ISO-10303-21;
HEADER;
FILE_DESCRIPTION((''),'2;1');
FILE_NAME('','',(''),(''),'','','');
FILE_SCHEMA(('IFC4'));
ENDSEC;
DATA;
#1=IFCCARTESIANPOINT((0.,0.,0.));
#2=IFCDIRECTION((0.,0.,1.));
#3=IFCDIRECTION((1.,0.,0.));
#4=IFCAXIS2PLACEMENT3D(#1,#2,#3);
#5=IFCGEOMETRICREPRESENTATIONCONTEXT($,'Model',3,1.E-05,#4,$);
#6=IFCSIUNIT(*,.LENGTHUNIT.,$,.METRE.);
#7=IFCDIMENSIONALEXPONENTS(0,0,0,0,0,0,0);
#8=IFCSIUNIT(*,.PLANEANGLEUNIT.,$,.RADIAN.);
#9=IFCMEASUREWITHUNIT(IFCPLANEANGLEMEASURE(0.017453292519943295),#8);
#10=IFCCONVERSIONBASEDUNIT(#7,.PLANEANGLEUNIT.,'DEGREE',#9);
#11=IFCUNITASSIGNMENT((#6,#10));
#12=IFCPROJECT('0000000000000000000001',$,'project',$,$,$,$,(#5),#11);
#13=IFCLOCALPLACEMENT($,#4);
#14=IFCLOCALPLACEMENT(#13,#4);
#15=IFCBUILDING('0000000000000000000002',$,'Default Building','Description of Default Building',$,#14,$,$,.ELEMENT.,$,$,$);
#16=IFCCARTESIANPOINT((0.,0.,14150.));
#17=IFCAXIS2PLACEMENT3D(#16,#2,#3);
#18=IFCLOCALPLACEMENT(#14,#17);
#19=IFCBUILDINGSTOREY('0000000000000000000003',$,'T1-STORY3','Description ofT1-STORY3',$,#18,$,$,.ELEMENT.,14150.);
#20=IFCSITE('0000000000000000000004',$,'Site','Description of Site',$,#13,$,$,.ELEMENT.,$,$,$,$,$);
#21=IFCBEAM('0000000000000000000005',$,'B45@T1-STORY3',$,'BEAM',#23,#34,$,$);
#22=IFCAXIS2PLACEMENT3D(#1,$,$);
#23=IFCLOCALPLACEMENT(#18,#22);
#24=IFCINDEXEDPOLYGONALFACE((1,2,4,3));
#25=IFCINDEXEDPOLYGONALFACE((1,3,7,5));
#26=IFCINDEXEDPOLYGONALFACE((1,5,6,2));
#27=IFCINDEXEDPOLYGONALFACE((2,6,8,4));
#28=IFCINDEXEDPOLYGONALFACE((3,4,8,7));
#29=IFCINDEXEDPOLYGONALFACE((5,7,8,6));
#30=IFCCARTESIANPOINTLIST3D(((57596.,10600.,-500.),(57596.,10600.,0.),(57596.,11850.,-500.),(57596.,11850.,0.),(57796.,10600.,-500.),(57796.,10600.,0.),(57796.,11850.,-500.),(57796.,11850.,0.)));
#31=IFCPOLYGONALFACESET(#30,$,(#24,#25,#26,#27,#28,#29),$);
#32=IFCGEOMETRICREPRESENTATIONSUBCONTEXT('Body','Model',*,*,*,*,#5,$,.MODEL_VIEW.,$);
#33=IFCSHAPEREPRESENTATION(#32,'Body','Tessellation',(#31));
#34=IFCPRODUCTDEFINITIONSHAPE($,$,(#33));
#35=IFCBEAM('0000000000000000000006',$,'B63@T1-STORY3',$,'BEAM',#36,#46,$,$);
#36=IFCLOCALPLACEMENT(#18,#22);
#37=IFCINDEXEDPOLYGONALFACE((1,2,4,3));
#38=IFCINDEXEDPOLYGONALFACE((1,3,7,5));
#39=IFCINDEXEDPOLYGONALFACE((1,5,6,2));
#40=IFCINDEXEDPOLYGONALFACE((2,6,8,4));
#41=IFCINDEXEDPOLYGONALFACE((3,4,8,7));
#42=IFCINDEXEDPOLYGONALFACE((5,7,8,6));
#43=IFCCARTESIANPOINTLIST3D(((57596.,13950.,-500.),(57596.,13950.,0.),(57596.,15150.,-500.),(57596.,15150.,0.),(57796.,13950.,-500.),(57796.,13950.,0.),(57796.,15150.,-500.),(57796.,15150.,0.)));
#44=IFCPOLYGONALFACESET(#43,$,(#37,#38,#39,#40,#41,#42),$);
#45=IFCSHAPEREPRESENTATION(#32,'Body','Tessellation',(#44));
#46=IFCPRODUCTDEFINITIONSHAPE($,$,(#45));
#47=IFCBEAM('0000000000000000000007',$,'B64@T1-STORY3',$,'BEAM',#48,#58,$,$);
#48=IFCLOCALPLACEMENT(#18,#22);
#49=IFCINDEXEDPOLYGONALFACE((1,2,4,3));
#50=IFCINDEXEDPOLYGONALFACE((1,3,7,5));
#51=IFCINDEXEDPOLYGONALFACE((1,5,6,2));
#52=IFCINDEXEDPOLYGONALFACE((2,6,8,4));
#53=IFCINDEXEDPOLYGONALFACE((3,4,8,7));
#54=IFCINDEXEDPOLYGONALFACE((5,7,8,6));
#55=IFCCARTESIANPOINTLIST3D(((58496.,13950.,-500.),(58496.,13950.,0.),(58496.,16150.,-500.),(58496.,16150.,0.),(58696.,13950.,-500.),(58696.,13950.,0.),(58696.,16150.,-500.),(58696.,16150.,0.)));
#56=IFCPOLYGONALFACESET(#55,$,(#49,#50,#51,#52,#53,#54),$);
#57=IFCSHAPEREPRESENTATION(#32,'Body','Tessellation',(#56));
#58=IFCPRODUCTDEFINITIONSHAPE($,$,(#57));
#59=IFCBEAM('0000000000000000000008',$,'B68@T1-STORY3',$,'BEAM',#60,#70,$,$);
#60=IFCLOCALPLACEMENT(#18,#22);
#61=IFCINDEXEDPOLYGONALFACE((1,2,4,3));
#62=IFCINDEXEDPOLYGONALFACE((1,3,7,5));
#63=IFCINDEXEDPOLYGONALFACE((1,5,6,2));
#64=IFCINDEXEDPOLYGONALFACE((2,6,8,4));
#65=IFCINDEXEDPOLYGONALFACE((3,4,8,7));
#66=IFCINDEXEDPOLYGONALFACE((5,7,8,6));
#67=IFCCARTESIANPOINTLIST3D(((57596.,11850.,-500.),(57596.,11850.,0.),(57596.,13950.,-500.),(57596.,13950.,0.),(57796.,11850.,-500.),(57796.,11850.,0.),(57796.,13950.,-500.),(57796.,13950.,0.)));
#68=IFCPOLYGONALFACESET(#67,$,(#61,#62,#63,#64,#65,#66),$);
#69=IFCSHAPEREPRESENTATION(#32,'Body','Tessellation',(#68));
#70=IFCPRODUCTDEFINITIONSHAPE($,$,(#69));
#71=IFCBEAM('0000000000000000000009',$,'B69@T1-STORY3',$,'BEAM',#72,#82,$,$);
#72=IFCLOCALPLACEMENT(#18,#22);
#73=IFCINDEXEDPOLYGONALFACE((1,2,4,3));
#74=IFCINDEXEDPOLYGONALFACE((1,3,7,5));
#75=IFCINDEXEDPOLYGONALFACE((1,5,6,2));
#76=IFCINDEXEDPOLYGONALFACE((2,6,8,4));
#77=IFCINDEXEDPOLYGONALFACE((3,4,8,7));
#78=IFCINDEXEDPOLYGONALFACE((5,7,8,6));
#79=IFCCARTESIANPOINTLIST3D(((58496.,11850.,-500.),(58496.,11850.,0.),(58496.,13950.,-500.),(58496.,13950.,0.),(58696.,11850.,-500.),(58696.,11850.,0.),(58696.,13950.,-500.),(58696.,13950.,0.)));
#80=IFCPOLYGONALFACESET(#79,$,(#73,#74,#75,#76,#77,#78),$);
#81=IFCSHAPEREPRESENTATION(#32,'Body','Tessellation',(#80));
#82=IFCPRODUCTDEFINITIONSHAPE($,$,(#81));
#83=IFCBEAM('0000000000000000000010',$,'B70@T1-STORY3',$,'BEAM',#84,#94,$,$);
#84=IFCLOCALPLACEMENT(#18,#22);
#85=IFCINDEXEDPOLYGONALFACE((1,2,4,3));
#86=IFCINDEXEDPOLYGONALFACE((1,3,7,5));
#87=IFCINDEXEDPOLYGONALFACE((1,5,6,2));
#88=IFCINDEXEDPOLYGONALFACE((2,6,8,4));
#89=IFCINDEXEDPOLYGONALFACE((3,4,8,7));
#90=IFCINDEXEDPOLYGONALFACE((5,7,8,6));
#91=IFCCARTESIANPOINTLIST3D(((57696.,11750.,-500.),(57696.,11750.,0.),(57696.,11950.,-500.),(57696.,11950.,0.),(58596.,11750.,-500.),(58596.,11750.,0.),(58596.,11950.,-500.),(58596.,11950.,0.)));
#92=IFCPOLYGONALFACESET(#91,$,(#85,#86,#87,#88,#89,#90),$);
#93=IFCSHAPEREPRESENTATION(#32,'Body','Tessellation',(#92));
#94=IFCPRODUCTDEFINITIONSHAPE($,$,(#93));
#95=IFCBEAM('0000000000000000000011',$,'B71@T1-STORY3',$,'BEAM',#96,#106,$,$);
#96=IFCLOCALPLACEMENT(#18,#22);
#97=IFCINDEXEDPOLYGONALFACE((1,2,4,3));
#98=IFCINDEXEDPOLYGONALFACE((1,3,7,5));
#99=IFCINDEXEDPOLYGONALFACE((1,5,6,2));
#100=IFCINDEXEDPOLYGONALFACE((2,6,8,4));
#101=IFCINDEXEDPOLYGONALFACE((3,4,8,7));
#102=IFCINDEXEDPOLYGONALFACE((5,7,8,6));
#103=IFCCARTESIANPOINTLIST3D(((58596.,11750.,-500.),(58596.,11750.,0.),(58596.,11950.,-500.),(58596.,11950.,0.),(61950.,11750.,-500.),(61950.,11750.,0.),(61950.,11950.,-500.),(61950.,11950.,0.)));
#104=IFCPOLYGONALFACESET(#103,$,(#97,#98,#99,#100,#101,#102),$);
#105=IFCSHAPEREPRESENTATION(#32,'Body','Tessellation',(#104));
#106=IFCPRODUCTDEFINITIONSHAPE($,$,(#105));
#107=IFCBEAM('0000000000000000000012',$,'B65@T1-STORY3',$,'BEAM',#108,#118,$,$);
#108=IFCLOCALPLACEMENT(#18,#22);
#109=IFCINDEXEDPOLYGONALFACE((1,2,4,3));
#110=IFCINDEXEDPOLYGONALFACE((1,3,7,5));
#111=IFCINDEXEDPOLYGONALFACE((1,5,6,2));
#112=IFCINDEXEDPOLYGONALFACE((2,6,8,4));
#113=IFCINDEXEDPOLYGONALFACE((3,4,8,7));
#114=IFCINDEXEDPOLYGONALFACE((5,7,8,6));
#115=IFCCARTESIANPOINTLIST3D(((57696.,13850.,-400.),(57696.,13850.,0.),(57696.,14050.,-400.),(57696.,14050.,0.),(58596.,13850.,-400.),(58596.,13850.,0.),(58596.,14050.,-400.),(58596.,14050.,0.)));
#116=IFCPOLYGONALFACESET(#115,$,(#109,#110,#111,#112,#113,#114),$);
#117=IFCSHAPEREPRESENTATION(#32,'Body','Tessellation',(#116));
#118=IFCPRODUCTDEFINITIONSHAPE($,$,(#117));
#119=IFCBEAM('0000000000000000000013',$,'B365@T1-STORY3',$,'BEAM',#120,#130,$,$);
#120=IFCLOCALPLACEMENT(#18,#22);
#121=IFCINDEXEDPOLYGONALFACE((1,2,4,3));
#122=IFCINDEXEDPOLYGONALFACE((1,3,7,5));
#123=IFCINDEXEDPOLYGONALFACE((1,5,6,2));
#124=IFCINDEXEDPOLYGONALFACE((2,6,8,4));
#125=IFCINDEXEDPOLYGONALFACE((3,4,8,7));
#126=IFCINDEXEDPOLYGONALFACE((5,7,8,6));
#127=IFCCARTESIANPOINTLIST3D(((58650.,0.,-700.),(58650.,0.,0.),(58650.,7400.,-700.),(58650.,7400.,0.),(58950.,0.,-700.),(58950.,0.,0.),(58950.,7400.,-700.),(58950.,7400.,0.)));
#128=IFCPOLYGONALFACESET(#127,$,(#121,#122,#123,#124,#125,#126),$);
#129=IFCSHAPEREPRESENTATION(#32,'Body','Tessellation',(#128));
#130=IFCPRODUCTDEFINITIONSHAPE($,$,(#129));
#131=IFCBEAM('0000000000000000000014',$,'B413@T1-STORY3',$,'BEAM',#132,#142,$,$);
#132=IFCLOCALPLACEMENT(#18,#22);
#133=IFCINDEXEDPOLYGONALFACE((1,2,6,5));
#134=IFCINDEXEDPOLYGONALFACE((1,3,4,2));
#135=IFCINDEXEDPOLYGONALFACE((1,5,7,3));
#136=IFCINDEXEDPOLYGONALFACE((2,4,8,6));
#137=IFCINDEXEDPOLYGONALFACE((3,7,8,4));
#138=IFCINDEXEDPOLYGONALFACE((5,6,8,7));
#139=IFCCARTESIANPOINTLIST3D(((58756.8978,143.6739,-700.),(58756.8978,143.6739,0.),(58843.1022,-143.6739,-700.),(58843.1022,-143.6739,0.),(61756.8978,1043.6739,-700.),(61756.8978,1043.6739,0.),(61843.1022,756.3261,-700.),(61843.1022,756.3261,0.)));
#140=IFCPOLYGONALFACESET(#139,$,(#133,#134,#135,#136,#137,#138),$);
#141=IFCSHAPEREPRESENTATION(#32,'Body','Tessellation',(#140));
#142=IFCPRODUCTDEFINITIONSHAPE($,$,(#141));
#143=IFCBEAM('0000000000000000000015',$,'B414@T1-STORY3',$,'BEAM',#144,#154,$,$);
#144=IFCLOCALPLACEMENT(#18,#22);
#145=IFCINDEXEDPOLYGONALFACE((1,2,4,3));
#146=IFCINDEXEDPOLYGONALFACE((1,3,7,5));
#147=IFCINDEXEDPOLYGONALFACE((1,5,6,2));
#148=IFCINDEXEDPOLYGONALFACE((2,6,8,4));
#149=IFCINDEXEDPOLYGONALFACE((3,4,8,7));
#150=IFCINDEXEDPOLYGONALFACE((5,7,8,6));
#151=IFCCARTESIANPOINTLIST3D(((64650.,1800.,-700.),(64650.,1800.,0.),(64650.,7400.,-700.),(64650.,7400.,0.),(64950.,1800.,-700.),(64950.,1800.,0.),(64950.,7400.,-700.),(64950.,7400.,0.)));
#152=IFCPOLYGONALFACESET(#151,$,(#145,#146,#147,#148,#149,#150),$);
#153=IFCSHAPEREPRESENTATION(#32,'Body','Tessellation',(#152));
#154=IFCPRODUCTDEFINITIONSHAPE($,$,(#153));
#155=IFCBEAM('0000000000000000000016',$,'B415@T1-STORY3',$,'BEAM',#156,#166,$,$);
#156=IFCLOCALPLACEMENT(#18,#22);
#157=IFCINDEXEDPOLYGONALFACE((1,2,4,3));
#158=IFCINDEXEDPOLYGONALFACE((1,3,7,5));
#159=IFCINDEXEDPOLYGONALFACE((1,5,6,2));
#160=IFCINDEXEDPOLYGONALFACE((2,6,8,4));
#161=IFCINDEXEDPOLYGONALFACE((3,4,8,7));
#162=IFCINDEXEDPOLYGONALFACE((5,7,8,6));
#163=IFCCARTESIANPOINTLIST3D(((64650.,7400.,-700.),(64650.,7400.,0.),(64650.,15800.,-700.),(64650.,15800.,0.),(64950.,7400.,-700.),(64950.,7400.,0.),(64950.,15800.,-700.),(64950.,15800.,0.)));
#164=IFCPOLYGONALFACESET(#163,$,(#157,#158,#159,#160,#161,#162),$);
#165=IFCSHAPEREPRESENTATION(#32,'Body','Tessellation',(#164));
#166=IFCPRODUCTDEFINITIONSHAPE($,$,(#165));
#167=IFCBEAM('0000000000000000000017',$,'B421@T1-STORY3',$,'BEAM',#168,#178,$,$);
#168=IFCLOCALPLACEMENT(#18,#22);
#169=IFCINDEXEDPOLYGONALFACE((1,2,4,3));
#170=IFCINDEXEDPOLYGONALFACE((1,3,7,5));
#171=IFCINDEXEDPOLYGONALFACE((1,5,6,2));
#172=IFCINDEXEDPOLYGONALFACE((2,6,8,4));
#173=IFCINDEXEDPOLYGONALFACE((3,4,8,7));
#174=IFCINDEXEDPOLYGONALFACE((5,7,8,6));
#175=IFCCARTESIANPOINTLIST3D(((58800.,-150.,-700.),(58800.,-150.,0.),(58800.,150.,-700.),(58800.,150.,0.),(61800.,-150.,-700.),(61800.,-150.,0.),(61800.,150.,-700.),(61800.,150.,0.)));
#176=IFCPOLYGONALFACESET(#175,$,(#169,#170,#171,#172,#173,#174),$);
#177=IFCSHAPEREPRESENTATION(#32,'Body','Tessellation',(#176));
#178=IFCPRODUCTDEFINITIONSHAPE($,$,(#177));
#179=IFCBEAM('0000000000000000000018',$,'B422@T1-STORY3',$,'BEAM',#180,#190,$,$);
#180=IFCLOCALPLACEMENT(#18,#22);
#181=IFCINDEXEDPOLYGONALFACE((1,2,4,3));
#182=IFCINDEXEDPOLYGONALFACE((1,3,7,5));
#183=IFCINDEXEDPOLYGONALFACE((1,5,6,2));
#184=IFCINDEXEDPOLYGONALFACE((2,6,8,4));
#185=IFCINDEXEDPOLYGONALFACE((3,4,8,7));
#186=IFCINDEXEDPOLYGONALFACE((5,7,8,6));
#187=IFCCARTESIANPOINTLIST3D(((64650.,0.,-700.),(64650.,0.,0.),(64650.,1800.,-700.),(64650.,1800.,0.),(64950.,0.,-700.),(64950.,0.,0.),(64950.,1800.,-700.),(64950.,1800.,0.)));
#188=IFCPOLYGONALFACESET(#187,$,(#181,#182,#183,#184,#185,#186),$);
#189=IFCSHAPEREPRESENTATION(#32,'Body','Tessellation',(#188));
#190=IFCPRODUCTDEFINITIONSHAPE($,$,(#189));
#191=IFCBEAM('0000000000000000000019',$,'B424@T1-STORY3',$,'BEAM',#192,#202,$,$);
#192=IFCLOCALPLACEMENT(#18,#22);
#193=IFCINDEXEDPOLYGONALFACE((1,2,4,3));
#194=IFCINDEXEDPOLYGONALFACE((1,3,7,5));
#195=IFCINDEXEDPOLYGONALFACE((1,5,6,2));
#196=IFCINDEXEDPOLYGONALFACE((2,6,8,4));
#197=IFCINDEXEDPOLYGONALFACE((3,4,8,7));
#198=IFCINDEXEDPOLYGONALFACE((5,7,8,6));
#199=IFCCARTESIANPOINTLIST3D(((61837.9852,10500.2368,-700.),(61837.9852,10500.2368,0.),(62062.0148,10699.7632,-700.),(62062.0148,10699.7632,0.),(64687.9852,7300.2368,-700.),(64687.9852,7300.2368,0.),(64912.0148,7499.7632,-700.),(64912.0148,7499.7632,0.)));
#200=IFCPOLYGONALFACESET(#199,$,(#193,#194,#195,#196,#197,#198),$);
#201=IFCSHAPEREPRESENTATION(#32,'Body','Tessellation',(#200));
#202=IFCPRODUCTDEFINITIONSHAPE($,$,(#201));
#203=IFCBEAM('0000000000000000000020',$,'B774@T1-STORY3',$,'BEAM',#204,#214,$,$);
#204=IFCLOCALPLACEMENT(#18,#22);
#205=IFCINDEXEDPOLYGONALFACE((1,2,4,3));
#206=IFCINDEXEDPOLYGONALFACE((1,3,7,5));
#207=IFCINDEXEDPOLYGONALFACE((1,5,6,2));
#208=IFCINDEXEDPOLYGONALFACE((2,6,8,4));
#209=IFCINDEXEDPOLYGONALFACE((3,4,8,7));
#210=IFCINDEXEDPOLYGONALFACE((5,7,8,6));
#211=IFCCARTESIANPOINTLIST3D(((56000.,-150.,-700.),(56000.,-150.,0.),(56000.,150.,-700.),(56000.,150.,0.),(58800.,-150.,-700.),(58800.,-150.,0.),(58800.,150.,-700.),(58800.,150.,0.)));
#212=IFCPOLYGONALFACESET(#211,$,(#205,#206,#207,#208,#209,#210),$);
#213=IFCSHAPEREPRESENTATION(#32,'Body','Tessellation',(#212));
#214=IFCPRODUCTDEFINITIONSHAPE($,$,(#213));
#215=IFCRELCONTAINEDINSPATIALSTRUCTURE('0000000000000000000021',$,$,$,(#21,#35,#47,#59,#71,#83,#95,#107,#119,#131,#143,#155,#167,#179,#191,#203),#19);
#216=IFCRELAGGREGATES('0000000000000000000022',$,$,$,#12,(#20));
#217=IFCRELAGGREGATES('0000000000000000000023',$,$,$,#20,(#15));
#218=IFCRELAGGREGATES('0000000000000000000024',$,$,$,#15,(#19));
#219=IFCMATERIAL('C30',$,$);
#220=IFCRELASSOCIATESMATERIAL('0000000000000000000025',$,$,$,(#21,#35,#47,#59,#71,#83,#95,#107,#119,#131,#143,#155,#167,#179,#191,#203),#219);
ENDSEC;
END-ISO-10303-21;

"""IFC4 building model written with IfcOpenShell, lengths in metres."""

from ifc_helpers import new_model, entity, si_unit, converted_unit, frame, origin_with_axes, place, context, subcontext, project, spatial, rectangle, extrude, material, element, save


model = new_model("IFC4")

# Units and contexts
model_context = context("Model", 3, precision=1e-05, world=origin_with_axes())
body_context = subcontext(model_context, "Body", "Model", "MODEL_VIEW")
ifc_project = project(units=[si_unit("LENGTHUNIT", "METRE"), converted_unit("PLANEANGLEUNIT", "DEGREE", entity("IfcPlaneAngleMeasure", 0.017453292519943295), si_unit("PLANEANGLEUNIT", "RADIAN"), dimensions=[0, 0, 0, 0, 0, 0, 0])], contexts=[model_context])

# Site, building, storey
site_placement = place(None, origin_with_axes())
site = spatial("IfcSite", under=ifc_project, at=site_placement, Name="Site", Description="Description of Site", CompositionType="ELEMENT")
building_placement = place(site_placement, origin_with_axes())
building = spatial("IfcBuilding", under=site, at=building_placement, Name="Default Building", Description="Description of Default Building", CompositionType="ELEMENT")
storey_placement = place(building_placement, frame((0.0, 0.0, 14150.0), z_axis=(0.0, 0.0, 1.0), x_axis=(1.0, 0.0, 0.0)))
storey = spatial("IfcBuildingStorey", under=building, at=storey_placement, Name="T1-STORY3", Description="Description ofT1-STORY3", CompositionType="ELEMENT", Elevation=14150.0)

# Beams
ifc_material_1 = material(Name="C30")
beam_1_placement = place(storey_placement, frame((57696.0, 10600.0, -250.0), z_axis=(0.0, 1.0, 0.0), x_axis=(-1.0, 0.0, 0.0)))
element("IfcBeam", 1, at=beam_1_placement, inside=storey, material=ifc_material_1, Name="B45@T1-STORY3", ObjectType="BEAM", context=body_context, shape_type="SweptSolid", body=[
    extrude(rectangle(XDim=200.0, YDim=500.0), origin_with_axes(), (0.0, 0.0, 1.0), 1250.0),
])
beam_2_placement = place(storey_placement, frame((57696.0, 13950.0, -250.0), z_axis=(0.0, 1.0, 0.0), x_axis=(-1.0, 0.0, 0.0)))
element("IfcBeam", 2, at=beam_2_placement, inside=storey, material=ifc_material_1, Name="B63@T1-STORY3", ObjectType="BEAM", context=body_context, shape_type="SweptSolid", body=[
    extrude(rectangle(XDim=200.0, YDim=500.0), origin_with_axes(), (0.0, 0.0, 1.0), 1200.0),
])
beam_3_placement = place(storey_placement, frame((58596.0, 13950.0, -250.0), z_axis=(0.0, 1.0, 0.0), x_axis=(-1.0, 0.0, 0.0)))
element("IfcBeam", 3, at=beam_3_placement, inside=storey, material=ifc_material_1, Name="B64@T1-STORY3", ObjectType="BEAM", context=body_context, shape_type="SweptSolid", body=[
    extrude(rectangle(XDim=200.0, YDim=500.0), origin_with_axes(), (0.0, 0.0, 1.0), 2200.0),
])
for number, where, z_axis, x_axis, name in (
    (4, (57696.0, 11850.0, -250.0), (0.0, 1.0, 0.0), (-1.0, 0.0, 0.0), "B68@T1-STORY3"),
    (5, (58596.0, 11850.0, -250.0), (0.0, 1.0, 0.0), (-1.0, 0.0, 0.0), "B69@T1-STORY3"),
):
    element("IfcBeam", number, at=place(storey_placement, frame(where, z_axis=z_axis, x_axis=x_axis)), inside=storey, material=ifc_material_1, Name=name, ObjectType="BEAM", context=body_context, shape_type="SweptSolid", body=[
        extrude(rectangle(XDim=200.0, YDim=500.0), origin_with_axes(), (0.0, 0.0, 1.0), 2100.0),
    ])
beam_4_placement = place(storey_placement, frame((57696.0, 11850.0, -250.0), z_axis=(1.0, 0.0, 0.0), x_axis=(0.0, 1.0, 0.0)))
element("IfcBeam", 6, at=beam_4_placement, inside=storey, material=ifc_material_1, Name="B70@T1-STORY3", ObjectType="BEAM", context=body_context, shape_type="SweptSolid", body=[
    extrude(rectangle(XDim=200.0, YDim=500.0), origin_with_axes(), (0.0, 0.0, 1.0), 900.0),
])
beam_5_placement = place(storey_placement, frame((58596.0, 11850.0, -250.0), z_axis=(1.0, 0.0, 0.0), x_axis=(0.0, 1.0, 0.0)))
element("IfcBeam", 7, at=beam_5_placement, inside=storey, material=ifc_material_1, Name="B71@T1-STORY3", ObjectType="BEAM", context=body_context, shape_type="SweptSolid", body=[
    extrude(rectangle(XDim=200.0, YDim=500.0), origin_with_axes(), (0.0, 0.0, 1.0), 3354.0),
])
beam_6_placement = place(storey_placement, frame((57696.0, 13950.0, -200.0), z_axis=(1.0, 0.0, 0.0), x_axis=(0.0, 1.0, 0.0)))
element("IfcBeam", 8, at=beam_6_placement, inside=storey, material=ifc_material_1, Name="B65@T1-STORY3", ObjectType="BEAM", context=body_context, shape_type="SweptSolid", body=[
    extrude(rectangle(XDim=200.0, YDim=400.0), origin_with_axes(), (0.0, 0.0, 1.0), 900.0),
])
beam_7_placement = place(storey_placement, frame((58800.0, 0.0, -350.0), z_axis=(0.0, 1.0, 0.0), x_axis=(-1.0, 0.0, 0.0)))
element("IfcBeam", 9, at=beam_7_placement, inside=storey, material=ifc_material_1, Name="B365@T1-STORY3", ObjectType="BEAM", context=body_context, shape_type="SweptSolid", body=[
    extrude(rectangle(XDim=300.0, YDim=700.0), origin_with_axes(), (0.0, 0.0, 1.0), 7400.0),
])
beam_8_placement = place(storey_placement, frame((58800.0, 0.0, -350.0), z_axis=(0.957826, 0.287348, 0.0), x_axis=(-0.287348, 0.957826, 0.0)))
element("IfcBeam", 10, at=beam_8_placement, inside=storey, material=ifc_material_1, Name="B413@T1-STORY3", ObjectType="BEAM", context=body_context, shape_type="SweptSolid", body=[
    extrude(rectangle(XDim=300.0, YDim=700.0), origin_with_axes(), (0.0, 0.0, 1.0), 3132.092),
])
beam_9_placement = place(storey_placement, frame((64800.0, 1800.0, -350.0), z_axis=(0.0, 1.0, 0.0), x_axis=(-1.0, 0.0, 0.0)))
element("IfcBeam", 11, at=beam_9_placement, inside=storey, material=ifc_material_1, Name="B414@T1-STORY3", ObjectType="BEAM", context=body_context, shape_type="SweptSolid", body=[
    extrude(rectangle(XDim=300.0, YDim=700.0), origin_with_axes(), (0.0, 0.0, 1.0), 5600.0),
])
beam_10_placement = place(storey_placement, frame((64800.0, 7400.0, -350.0), z_axis=(0.0, 1.0, 0.0), x_axis=(-1.0, 0.0, 0.0)))
element("IfcBeam", 12, at=beam_10_placement, inside=storey, material=ifc_material_1, Name="B415@T1-STORY3", ObjectType="BEAM", context=body_context, shape_type="SweptSolid", body=[
    extrude(rectangle(XDim=300.0, YDim=700.0), origin_with_axes(), (0.0, 0.0, 1.0), 8400.0),
])
beam_11_placement = place(storey_placement, frame((58800.0, 0.0, -350.0), z_axis=(1.0, 0.0, 0.0), x_axis=(0.0, 1.0, 0.0)))
element("IfcBeam", 13, at=beam_11_placement, inside=storey, material=ifc_material_1, Name="B421@T1-STORY3", ObjectType="BEAM", context=body_context, shape_type="SweptSolid", body=[
    extrude(rectangle(XDim=300.0, YDim=700.0), origin_with_axes(), (0.0, 0.0, 1.0), 3000.0),
])
beam_12_placement = place(storey_placement, frame((64800.0, 0.0, -350.0), z_axis=(0.0, 1.0, 0.0), x_axis=(-1.0, 0.0, 0.0)))
element("IfcBeam", 14, at=beam_12_placement, inside=storey, material=ifc_material_1, Name="B422@T1-STORY3", ObjectType="BEAM", context=body_context, shape_type="SweptSolid", body=[
    extrude(rectangle(XDim=300.0, YDim=700.0), origin_with_axes(), (0.0, 0.0, 1.0), 1800.0),
])
beam_13_placement = place(storey_placement, frame((61950.0, 10600.0, -350.0), z_axis=(0.665088, -0.746765, 0.0), x_axis=(0.746765, 0.665088, 0.0)))
element("IfcBeam", 15, at=beam_13_placement, inside=storey, material=ifc_material_1, Name="B424@T1-STORY3", ObjectType="BEAM", context=body_context, shape_type="SweptSolid", body=[
    extrude(rectangle(XDim=300.0, YDim=700.0), origin_with_axes(), (0.0, 0.0, 1.0), 4285.1488),
])
beam_14_placement = place(storey_placement, frame((56000.0, 0.0, -350.0), z_axis=(1.0, 0.0, 0.0), x_axis=(0.0, 1.0, 0.0)))
element("IfcBeam", 16, at=beam_14_placement, inside=storey, material=ifc_material_1, Name="B774@T1-STORY3", ObjectType="BEAM", context=body_context, shape_type="SweptSolid", body=[
    extrude(rectangle(XDim=300.0, YDim=700.0), origin_with_axes(), (0.0, 0.0, 1.0), 2800.0),
])

save(model, "model.ifc")
